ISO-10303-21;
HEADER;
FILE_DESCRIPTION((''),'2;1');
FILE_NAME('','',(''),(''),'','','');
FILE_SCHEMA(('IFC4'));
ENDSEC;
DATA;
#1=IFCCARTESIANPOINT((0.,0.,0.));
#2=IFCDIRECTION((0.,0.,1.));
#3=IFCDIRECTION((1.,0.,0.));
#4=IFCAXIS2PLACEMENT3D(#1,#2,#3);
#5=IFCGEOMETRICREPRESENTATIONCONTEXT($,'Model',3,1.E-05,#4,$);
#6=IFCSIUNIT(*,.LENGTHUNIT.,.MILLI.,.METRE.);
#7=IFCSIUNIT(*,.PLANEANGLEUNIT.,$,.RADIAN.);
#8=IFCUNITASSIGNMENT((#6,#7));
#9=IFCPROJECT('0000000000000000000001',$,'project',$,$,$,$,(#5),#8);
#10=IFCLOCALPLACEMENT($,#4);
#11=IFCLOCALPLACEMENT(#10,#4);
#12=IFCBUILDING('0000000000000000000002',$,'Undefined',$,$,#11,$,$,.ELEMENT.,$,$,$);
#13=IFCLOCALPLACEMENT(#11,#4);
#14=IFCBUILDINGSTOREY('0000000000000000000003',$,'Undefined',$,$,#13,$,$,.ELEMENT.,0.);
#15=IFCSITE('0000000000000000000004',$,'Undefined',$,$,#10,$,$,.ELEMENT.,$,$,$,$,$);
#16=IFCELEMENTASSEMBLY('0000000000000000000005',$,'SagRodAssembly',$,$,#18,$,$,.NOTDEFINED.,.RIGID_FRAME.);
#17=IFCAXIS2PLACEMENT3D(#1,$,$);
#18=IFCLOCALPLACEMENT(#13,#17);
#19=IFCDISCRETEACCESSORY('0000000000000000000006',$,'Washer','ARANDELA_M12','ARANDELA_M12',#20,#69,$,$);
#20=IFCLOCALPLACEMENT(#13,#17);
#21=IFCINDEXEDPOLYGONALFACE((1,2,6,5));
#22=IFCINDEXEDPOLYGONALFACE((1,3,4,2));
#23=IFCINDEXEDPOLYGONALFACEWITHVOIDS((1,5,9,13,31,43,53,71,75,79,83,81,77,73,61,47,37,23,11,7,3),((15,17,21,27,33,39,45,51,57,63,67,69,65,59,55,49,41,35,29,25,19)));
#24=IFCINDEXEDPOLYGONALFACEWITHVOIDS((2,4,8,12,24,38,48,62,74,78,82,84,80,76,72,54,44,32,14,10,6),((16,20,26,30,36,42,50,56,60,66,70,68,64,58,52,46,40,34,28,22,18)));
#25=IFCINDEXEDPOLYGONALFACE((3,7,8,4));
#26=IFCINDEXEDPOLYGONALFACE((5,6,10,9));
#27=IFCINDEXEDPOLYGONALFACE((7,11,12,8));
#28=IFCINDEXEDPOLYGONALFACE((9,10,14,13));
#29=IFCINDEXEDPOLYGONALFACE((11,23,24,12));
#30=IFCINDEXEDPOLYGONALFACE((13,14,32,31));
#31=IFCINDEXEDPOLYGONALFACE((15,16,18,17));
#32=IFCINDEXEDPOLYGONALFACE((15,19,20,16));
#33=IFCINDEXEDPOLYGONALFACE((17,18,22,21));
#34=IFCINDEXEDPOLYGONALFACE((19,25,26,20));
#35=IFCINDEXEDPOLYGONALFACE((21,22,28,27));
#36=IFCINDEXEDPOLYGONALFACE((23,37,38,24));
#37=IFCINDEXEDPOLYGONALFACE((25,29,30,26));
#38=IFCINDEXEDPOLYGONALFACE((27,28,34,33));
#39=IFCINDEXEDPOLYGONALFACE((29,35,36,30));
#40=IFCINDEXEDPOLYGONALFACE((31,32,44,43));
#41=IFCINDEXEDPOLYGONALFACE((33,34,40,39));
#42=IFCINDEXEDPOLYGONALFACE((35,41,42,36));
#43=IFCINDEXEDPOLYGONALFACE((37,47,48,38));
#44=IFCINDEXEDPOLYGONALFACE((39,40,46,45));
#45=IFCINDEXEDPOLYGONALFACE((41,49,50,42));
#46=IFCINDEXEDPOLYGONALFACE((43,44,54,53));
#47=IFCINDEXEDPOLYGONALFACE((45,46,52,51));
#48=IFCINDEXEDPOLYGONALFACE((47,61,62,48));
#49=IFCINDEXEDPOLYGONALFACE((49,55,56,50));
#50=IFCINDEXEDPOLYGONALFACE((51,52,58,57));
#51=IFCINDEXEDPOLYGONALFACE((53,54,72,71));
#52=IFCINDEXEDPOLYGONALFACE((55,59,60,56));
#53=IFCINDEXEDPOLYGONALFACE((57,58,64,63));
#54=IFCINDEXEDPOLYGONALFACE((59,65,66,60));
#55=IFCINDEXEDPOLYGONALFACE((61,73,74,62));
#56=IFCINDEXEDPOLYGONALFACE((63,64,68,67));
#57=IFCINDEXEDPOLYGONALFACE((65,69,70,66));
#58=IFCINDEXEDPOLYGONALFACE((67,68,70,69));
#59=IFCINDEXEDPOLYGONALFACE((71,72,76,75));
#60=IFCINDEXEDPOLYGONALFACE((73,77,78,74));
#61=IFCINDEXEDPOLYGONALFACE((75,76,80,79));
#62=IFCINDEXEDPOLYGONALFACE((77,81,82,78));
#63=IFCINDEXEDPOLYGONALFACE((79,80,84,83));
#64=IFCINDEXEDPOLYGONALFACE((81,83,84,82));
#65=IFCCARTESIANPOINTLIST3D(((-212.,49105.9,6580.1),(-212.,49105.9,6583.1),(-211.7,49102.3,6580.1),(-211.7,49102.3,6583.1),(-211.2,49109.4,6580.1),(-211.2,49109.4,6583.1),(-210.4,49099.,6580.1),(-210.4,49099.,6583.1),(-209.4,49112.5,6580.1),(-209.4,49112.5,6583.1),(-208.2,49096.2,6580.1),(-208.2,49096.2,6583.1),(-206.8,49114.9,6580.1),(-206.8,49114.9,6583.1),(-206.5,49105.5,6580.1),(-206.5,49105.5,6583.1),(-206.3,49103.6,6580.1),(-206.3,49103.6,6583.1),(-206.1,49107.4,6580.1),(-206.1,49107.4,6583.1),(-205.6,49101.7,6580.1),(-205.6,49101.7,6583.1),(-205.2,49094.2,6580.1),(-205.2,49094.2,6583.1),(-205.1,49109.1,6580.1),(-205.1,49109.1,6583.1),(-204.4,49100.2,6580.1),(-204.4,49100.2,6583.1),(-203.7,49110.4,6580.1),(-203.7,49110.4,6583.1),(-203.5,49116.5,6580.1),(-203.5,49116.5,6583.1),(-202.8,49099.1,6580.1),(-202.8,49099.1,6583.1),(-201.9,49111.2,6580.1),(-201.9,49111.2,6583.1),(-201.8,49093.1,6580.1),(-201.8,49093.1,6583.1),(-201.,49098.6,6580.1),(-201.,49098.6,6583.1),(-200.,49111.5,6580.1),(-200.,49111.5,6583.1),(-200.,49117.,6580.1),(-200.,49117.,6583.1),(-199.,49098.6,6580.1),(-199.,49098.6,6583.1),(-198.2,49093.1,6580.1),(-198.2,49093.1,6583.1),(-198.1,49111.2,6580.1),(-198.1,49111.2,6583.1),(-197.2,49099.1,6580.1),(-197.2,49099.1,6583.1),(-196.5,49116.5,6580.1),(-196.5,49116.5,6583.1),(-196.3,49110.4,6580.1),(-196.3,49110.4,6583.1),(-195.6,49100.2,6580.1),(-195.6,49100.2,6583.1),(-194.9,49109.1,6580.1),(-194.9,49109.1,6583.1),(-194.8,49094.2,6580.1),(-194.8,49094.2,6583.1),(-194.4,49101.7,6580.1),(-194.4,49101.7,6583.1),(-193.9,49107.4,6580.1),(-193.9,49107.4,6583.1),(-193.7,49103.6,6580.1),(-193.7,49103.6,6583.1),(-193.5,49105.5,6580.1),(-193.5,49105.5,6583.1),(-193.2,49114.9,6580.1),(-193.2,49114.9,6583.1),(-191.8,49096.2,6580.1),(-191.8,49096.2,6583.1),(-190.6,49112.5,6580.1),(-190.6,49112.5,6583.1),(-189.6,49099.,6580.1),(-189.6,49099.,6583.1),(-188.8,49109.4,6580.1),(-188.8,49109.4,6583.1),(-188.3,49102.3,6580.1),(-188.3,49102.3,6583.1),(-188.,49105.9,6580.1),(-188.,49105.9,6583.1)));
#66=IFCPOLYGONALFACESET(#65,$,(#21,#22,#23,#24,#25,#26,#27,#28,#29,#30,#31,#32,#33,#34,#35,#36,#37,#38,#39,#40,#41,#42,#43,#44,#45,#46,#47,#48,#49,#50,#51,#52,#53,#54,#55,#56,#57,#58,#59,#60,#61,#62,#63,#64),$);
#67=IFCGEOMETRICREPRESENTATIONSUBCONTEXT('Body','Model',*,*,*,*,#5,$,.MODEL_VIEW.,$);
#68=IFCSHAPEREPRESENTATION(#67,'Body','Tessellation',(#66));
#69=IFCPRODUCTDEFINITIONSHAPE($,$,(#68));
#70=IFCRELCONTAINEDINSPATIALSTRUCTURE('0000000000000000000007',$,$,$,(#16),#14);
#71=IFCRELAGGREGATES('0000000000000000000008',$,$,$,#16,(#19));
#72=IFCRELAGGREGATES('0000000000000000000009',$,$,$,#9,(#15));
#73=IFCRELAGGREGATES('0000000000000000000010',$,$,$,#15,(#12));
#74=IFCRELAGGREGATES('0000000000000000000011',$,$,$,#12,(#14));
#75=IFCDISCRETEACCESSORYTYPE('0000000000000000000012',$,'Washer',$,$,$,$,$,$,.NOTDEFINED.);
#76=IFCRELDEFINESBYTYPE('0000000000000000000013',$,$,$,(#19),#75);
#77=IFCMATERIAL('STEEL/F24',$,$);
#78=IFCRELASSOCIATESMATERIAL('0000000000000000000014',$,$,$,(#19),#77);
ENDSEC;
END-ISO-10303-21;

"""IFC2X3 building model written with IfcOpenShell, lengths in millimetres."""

from ifc_helpers import new_model, si_unit, frame, origin_with_axes, origin_2d_with_axis, place, context, subcontext, project, spatial, hollow_circle, extrude, material, type_object, element, aggregate, save


model = new_model("IFC2X3")

# Units and contexts
model_context = context("Model", 3, precision=1e-05, world=origin_with_axes())
body_context = subcontext(model_context, "Body", "Model", "MODEL_VIEW")
ifc_project = project(units=[si_unit("LENGTHUNIT", "METRE", prefix="MILLI"), si_unit("PLANEANGLEUNIT", "RADIAN")], contexts=[model_context])

# Site, building, storey
site_placement = place(None, origin_with_axes())
site = spatial("IfcSite", under=ifc_project, at=site_placement, Name="Undefined", CompositionType="ELEMENT")
building_placement = place(site_placement, origin_with_axes())
building = spatial("IfcBuilding", under=site, at=building_placement, Name="Undefined", CompositionType="ELEMENT")
storey_placement = place(building_placement, origin_with_axes())
storey = spatial("IfcBuildingStorey", under=building, at=storey_placement, Name="Undefined", CompositionType="ELEMENT", Elevation=0.0)

# Shared definitions
ifc_material_1 = material(Name="STEEL/F24")

# Element assembly, discrete accessory
assembly_1_placement = place(storey_placement, origin_with_axes())
assembly_1 = element("IfcElementAssembly", 1, at=assembly_1_placement, inside=storey, Name="SagRodAssembly", AssemblyPlace="NOTDEFINED", PredefinedType="RIGID_FRAME")
discrete_accessory_type_1 = type_object("IfcDiscreteAccessoryType", Name="Washer")
discrete_accessory_1_placement = place(assembly_1_placement, frame((-200.0, 49105.0, 6580.1), z_axis=(0.0, 0.0, 1.0), x_axis=(1.0, 0.0, 0.0)))
discrete_accessory_1 = element("IfcDiscreteAccessory", 2, at=discrete_accessory_1_placement, type_object=discrete_accessory_type_1, material=ifc_material_1, Name="Washer", Description="ARANDELA_M12", ObjectType="ARANDELA_M12", context=body_context, shape_type="SweptSolid", body=[
    extrude(hollow_circle(Radius=12.0, WallThickness=5.5, at=origin_2d_with_axis()), frame((0.0, 0.0, 3.0), z_axis=(0.0, 0.0, -1.0), x_axis=(0.0, 1.0, 0.0)), (0.0, 0.0, 1.0), 3.0),
])
aggregate(assembly_1, [discrete_accessory_1])

save(model, "model.ifc")
